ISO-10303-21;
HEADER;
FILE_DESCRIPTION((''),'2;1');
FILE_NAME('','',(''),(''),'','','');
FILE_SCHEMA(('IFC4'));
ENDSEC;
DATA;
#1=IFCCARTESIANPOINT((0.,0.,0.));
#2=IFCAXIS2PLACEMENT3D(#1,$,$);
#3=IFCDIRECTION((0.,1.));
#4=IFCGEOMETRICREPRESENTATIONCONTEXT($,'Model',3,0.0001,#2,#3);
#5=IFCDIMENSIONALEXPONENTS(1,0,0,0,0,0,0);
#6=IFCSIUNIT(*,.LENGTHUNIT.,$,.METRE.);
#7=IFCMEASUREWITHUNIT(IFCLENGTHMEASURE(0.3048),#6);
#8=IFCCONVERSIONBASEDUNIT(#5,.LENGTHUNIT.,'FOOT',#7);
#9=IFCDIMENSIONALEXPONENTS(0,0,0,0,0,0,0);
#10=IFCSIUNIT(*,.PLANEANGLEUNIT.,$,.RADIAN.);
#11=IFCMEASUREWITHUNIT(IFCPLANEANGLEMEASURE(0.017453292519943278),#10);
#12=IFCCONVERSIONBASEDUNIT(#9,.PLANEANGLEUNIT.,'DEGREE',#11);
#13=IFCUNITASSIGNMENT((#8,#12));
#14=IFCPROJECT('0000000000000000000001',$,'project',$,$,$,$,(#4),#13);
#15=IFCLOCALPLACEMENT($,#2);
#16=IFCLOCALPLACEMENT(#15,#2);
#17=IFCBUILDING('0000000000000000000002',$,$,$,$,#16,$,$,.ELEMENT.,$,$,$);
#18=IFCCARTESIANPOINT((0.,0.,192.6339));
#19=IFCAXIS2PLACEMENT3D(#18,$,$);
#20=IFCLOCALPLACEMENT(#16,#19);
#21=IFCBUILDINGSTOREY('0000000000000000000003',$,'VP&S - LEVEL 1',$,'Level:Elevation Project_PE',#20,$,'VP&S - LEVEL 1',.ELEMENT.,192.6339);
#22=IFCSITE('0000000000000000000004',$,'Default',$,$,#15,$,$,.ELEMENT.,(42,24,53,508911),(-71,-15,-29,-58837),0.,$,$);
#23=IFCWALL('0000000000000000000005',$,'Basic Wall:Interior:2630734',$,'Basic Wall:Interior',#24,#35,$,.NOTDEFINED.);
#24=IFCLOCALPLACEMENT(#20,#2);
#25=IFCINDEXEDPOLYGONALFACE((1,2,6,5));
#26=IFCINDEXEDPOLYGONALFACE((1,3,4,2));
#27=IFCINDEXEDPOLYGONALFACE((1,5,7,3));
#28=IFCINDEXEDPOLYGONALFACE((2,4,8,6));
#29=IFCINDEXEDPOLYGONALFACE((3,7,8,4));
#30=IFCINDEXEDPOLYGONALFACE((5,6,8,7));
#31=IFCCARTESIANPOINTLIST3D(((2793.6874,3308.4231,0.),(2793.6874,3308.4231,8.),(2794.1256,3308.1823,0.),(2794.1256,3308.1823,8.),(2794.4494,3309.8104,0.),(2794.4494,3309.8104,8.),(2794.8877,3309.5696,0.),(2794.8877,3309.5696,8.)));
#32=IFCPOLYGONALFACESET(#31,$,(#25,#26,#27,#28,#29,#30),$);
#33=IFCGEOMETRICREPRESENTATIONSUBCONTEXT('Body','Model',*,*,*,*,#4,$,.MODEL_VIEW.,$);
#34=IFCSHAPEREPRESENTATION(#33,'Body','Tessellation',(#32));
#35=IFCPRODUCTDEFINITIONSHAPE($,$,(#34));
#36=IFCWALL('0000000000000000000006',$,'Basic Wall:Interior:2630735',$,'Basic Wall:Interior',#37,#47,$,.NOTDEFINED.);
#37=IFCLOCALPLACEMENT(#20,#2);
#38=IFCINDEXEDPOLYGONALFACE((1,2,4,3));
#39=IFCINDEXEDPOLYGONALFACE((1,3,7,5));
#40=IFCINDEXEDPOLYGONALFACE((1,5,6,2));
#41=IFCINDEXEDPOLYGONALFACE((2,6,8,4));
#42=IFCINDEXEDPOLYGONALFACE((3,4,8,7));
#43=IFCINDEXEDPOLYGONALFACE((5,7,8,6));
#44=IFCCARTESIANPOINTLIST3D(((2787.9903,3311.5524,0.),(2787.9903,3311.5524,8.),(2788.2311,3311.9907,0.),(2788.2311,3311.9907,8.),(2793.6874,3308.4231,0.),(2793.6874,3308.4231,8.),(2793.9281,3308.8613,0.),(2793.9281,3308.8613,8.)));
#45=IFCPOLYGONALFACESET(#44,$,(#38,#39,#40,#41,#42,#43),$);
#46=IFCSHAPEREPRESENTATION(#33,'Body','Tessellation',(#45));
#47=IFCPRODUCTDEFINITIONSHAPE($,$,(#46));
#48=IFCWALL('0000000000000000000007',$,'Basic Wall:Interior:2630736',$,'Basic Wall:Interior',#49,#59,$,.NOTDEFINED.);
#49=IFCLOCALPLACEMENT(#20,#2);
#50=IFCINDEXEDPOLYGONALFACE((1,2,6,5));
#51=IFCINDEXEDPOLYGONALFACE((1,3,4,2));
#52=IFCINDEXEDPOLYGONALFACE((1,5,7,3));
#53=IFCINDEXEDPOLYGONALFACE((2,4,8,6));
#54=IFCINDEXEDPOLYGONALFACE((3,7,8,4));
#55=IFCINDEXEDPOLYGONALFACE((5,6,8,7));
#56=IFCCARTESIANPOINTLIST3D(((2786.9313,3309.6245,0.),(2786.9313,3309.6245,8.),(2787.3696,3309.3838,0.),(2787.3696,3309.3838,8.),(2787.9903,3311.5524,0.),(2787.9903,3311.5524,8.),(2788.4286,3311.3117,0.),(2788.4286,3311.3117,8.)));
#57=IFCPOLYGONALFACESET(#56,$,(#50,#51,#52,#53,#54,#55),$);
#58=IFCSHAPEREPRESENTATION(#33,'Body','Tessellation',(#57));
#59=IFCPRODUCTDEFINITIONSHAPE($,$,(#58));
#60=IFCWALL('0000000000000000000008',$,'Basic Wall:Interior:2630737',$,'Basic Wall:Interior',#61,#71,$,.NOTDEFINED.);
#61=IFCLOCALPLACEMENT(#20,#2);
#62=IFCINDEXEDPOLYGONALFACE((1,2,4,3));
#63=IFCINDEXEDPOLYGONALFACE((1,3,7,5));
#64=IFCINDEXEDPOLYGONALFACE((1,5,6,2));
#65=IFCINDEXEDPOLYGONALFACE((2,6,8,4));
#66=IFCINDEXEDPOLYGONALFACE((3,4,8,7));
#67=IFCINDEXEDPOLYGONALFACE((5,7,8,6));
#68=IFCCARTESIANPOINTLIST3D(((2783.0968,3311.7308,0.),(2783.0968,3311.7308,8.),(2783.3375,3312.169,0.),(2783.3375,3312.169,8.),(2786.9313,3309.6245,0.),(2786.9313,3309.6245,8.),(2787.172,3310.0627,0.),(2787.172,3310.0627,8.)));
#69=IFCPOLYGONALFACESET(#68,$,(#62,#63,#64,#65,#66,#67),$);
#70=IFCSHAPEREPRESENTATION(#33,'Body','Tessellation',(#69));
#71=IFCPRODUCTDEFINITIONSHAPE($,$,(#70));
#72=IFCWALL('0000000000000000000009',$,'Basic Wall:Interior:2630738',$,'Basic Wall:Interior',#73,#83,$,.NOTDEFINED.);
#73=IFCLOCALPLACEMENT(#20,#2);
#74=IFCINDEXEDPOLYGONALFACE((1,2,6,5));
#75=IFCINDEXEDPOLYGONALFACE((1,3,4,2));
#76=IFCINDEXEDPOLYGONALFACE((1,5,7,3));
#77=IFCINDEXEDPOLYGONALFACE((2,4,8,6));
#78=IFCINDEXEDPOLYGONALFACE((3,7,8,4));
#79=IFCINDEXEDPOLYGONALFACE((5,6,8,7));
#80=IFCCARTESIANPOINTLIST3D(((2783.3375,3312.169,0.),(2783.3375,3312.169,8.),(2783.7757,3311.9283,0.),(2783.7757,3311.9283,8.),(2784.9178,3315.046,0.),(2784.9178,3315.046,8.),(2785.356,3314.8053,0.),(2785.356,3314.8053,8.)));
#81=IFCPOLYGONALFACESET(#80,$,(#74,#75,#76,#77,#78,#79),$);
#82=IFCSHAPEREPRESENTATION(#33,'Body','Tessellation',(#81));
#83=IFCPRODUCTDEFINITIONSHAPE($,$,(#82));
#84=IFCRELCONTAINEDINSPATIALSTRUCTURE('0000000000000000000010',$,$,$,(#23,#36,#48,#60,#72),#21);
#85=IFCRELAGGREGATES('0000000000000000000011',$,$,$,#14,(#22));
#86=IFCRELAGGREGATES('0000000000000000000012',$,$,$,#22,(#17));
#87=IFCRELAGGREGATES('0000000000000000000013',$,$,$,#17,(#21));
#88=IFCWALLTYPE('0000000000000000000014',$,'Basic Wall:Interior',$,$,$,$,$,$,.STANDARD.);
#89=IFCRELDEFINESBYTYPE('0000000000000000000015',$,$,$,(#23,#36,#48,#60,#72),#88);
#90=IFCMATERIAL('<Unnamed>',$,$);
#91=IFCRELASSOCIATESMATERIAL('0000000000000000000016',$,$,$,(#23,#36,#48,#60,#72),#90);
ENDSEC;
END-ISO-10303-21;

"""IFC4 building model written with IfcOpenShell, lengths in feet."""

from ifc_helpers import new_model, entity, si_unit, converted_unit, direction, frame, origin, place, context, subcontext, project, spatial, indexed_curve, outline, extrude, material, type_object, element, save


model = new_model("IFC4")

# Units and contexts
model_context = context("Model", 3, precision=0.0001, world=origin(), true_north=direction((0.0, 1.0)))
body_context = subcontext(model_context, "Body", "Model", "MODEL_VIEW")
ifc_project = project(units=[converted_unit("LENGTHUNIT", "FOOT", entity("IfcLengthMeasure", 0.3048), si_unit("LENGTHUNIT", "METRE"), dimensions=[1, 0, 0, 0, 0, 0, 0]), converted_unit("PLANEANGLEUNIT", "DEGREE", entity("IfcPlaneAngleMeasure", 0.017453292519943278), si_unit("PLANEANGLEUNIT", "RADIAN"), dimensions=[0, 0, 0, 0, 0, 0, 0])], contexts=[model_context])

# Site, building, storey
site_placement = place(None, origin())
site = spatial("IfcSite", under=ifc_project, at=site_placement, Name="Default", CompositionType="ELEMENT", RefLatitude=(42, 24, 53, 508911), RefLongitude=(-71, -15, -29, -58837), RefElevation=0.0)
building_placement = place(site_placement, origin())
building = spatial("IfcBuilding", under=site, at=building_placement, CompositionType="ELEMENT")
storey_placement = place(building_placement, frame((0.0, 0.0, 192.6339)))
storey = spatial("IfcBuildingStorey", under=building, at=storey_placement, Name="VP&S - LEVEL 1", ObjectType="Level:Elevation Project_PE", LongName="VP&S - LEVEL 1", CompositionType="ELEMENT", Elevation=192.6339)

# Walls
ifc_material = material(Name="<Unnamed>")
wall_type = type_object("IfcWallType", Name="Basic Wall:Interior", PredefinedType="STANDARD")
wall_1_placement = place(storey_placement, frame((2794.6686, 3309.69, 0.0), z_axis=(0.0, 0.0, 1.0), x_axis=(-0.481445, -0.876477, 0.0)))
element("IfcWall", 1, at=wall_1_placement, inside=storey, type_object=wall_type, material=ifc_material, Name="Basic Wall:Interior:2630734", ObjectType="Basic Wall:Interior", PredefinedType="NOTDEFINED", context=body_context, shape_type="SweptSolid", body=[
    extrude(outline(indexed_curve([(1.5828, 0.25), (0.0, 0.25), (0.0, -0.25), (1.5828, -0.25), (1.5828, 0.25)], self_intersect=False)), origin(), (0.0, 0.0, 1.0), 8.0),
])
wall_2_placement = place(storey_placement, frame((2793.8078, 3308.6422, 0.0), z_axis=(0.0, 0.0, 1.0), x_axis=(-0.876477, 0.481445, 0.0)))
element("IfcWall", 2, at=wall_2_placement, inside=storey, type_object=wall_type, material=ifc_material, Name="Basic Wall:Interior:2630735", ObjectType="Basic Wall:Interior", PredefinedType="NOTDEFINED", context=body_context, shape_type="SweptSolid", body=[
    extrude(outline(indexed_curve([(6.5, 0.25), (0.0, 0.25), (0.0, -0.25), (6.5, -0.25), (6.5, 0.25)], self_intersect=False)), origin(), (0.0, 0.0, 1.0), 8.0),
])
wall_3_placement = place(storey_placement, frame((2788.2094, 3311.4321, 0.0), z_axis=(0.0, 0.0, 1.0), x_axis=(-0.481445, -0.876477, 0.0)))
element("IfcWall", 3, at=wall_3_placement, inside=storey, type_object=wall_type, material=ifc_material, Name="Basic Wall:Interior:2630736", ObjectType="Basic Wall:Interior", PredefinedType="NOTDEFINED", context=body_context, shape_type="SweptSolid", body=[
    extrude(outline(indexed_curve([(2.1997, 0.25), (0.0, 0.25), (0.0, -0.25), (2.1997, -0.25), (2.1997, 0.25)], self_intersect=False)), origin(), (0.0, 0.0, 1.0), 8.0),
])
wall_4_placement = place(storey_placement, frame((2787.0517, 3309.8436, 0.0), z_axis=(0.0, 0.0, 1.0), x_axis=(-0.876477, 0.481445, 0.0)))
element("IfcWall", 4, at=wall_4_placement, inside=storey, type_object=wall_type, material=ifc_material, Name="Basic Wall:Interior:2630737", ObjectType="Basic Wall:Interior", PredefinedType="NOTDEFINED", context=body_context, shape_type="SweptSolid", body=[
    extrude(outline(indexed_curve([(4.375, 0.25), (0.0, 0.25), (0.0, -0.25), (4.375, -0.25), (4.375, 0.25)], self_intersect=False)), origin(), (0.0, 0.0, 1.0), 8.0),
])
wall_5_placement = place(storey_placement, frame((2783.5566, 3312.0487, 0.0), z_axis=(0.0, 0.0, 1.0), x_axis=(0.481445, 0.876477, 0.0)))
element("IfcWall", 5, at=wall_5_placement, inside=storey, type_object=wall_type, material=ifc_material, Name="Basic Wall:Interior:2630738", ObjectType="Basic Wall:Interior", PredefinedType="NOTDEFINED", context=body_context, shape_type="SweptSolid", body=[
    extrude(outline(indexed_curve([(3.2825, 0.25), (0.0, 0.25), (0.0, -0.25), (3.2825, -0.25), (3.2825, 0.25)], self_intersect=False)), origin(), (0.0, 0.0, 1.0), 8.0),
])

save(model, "model.ifc")
